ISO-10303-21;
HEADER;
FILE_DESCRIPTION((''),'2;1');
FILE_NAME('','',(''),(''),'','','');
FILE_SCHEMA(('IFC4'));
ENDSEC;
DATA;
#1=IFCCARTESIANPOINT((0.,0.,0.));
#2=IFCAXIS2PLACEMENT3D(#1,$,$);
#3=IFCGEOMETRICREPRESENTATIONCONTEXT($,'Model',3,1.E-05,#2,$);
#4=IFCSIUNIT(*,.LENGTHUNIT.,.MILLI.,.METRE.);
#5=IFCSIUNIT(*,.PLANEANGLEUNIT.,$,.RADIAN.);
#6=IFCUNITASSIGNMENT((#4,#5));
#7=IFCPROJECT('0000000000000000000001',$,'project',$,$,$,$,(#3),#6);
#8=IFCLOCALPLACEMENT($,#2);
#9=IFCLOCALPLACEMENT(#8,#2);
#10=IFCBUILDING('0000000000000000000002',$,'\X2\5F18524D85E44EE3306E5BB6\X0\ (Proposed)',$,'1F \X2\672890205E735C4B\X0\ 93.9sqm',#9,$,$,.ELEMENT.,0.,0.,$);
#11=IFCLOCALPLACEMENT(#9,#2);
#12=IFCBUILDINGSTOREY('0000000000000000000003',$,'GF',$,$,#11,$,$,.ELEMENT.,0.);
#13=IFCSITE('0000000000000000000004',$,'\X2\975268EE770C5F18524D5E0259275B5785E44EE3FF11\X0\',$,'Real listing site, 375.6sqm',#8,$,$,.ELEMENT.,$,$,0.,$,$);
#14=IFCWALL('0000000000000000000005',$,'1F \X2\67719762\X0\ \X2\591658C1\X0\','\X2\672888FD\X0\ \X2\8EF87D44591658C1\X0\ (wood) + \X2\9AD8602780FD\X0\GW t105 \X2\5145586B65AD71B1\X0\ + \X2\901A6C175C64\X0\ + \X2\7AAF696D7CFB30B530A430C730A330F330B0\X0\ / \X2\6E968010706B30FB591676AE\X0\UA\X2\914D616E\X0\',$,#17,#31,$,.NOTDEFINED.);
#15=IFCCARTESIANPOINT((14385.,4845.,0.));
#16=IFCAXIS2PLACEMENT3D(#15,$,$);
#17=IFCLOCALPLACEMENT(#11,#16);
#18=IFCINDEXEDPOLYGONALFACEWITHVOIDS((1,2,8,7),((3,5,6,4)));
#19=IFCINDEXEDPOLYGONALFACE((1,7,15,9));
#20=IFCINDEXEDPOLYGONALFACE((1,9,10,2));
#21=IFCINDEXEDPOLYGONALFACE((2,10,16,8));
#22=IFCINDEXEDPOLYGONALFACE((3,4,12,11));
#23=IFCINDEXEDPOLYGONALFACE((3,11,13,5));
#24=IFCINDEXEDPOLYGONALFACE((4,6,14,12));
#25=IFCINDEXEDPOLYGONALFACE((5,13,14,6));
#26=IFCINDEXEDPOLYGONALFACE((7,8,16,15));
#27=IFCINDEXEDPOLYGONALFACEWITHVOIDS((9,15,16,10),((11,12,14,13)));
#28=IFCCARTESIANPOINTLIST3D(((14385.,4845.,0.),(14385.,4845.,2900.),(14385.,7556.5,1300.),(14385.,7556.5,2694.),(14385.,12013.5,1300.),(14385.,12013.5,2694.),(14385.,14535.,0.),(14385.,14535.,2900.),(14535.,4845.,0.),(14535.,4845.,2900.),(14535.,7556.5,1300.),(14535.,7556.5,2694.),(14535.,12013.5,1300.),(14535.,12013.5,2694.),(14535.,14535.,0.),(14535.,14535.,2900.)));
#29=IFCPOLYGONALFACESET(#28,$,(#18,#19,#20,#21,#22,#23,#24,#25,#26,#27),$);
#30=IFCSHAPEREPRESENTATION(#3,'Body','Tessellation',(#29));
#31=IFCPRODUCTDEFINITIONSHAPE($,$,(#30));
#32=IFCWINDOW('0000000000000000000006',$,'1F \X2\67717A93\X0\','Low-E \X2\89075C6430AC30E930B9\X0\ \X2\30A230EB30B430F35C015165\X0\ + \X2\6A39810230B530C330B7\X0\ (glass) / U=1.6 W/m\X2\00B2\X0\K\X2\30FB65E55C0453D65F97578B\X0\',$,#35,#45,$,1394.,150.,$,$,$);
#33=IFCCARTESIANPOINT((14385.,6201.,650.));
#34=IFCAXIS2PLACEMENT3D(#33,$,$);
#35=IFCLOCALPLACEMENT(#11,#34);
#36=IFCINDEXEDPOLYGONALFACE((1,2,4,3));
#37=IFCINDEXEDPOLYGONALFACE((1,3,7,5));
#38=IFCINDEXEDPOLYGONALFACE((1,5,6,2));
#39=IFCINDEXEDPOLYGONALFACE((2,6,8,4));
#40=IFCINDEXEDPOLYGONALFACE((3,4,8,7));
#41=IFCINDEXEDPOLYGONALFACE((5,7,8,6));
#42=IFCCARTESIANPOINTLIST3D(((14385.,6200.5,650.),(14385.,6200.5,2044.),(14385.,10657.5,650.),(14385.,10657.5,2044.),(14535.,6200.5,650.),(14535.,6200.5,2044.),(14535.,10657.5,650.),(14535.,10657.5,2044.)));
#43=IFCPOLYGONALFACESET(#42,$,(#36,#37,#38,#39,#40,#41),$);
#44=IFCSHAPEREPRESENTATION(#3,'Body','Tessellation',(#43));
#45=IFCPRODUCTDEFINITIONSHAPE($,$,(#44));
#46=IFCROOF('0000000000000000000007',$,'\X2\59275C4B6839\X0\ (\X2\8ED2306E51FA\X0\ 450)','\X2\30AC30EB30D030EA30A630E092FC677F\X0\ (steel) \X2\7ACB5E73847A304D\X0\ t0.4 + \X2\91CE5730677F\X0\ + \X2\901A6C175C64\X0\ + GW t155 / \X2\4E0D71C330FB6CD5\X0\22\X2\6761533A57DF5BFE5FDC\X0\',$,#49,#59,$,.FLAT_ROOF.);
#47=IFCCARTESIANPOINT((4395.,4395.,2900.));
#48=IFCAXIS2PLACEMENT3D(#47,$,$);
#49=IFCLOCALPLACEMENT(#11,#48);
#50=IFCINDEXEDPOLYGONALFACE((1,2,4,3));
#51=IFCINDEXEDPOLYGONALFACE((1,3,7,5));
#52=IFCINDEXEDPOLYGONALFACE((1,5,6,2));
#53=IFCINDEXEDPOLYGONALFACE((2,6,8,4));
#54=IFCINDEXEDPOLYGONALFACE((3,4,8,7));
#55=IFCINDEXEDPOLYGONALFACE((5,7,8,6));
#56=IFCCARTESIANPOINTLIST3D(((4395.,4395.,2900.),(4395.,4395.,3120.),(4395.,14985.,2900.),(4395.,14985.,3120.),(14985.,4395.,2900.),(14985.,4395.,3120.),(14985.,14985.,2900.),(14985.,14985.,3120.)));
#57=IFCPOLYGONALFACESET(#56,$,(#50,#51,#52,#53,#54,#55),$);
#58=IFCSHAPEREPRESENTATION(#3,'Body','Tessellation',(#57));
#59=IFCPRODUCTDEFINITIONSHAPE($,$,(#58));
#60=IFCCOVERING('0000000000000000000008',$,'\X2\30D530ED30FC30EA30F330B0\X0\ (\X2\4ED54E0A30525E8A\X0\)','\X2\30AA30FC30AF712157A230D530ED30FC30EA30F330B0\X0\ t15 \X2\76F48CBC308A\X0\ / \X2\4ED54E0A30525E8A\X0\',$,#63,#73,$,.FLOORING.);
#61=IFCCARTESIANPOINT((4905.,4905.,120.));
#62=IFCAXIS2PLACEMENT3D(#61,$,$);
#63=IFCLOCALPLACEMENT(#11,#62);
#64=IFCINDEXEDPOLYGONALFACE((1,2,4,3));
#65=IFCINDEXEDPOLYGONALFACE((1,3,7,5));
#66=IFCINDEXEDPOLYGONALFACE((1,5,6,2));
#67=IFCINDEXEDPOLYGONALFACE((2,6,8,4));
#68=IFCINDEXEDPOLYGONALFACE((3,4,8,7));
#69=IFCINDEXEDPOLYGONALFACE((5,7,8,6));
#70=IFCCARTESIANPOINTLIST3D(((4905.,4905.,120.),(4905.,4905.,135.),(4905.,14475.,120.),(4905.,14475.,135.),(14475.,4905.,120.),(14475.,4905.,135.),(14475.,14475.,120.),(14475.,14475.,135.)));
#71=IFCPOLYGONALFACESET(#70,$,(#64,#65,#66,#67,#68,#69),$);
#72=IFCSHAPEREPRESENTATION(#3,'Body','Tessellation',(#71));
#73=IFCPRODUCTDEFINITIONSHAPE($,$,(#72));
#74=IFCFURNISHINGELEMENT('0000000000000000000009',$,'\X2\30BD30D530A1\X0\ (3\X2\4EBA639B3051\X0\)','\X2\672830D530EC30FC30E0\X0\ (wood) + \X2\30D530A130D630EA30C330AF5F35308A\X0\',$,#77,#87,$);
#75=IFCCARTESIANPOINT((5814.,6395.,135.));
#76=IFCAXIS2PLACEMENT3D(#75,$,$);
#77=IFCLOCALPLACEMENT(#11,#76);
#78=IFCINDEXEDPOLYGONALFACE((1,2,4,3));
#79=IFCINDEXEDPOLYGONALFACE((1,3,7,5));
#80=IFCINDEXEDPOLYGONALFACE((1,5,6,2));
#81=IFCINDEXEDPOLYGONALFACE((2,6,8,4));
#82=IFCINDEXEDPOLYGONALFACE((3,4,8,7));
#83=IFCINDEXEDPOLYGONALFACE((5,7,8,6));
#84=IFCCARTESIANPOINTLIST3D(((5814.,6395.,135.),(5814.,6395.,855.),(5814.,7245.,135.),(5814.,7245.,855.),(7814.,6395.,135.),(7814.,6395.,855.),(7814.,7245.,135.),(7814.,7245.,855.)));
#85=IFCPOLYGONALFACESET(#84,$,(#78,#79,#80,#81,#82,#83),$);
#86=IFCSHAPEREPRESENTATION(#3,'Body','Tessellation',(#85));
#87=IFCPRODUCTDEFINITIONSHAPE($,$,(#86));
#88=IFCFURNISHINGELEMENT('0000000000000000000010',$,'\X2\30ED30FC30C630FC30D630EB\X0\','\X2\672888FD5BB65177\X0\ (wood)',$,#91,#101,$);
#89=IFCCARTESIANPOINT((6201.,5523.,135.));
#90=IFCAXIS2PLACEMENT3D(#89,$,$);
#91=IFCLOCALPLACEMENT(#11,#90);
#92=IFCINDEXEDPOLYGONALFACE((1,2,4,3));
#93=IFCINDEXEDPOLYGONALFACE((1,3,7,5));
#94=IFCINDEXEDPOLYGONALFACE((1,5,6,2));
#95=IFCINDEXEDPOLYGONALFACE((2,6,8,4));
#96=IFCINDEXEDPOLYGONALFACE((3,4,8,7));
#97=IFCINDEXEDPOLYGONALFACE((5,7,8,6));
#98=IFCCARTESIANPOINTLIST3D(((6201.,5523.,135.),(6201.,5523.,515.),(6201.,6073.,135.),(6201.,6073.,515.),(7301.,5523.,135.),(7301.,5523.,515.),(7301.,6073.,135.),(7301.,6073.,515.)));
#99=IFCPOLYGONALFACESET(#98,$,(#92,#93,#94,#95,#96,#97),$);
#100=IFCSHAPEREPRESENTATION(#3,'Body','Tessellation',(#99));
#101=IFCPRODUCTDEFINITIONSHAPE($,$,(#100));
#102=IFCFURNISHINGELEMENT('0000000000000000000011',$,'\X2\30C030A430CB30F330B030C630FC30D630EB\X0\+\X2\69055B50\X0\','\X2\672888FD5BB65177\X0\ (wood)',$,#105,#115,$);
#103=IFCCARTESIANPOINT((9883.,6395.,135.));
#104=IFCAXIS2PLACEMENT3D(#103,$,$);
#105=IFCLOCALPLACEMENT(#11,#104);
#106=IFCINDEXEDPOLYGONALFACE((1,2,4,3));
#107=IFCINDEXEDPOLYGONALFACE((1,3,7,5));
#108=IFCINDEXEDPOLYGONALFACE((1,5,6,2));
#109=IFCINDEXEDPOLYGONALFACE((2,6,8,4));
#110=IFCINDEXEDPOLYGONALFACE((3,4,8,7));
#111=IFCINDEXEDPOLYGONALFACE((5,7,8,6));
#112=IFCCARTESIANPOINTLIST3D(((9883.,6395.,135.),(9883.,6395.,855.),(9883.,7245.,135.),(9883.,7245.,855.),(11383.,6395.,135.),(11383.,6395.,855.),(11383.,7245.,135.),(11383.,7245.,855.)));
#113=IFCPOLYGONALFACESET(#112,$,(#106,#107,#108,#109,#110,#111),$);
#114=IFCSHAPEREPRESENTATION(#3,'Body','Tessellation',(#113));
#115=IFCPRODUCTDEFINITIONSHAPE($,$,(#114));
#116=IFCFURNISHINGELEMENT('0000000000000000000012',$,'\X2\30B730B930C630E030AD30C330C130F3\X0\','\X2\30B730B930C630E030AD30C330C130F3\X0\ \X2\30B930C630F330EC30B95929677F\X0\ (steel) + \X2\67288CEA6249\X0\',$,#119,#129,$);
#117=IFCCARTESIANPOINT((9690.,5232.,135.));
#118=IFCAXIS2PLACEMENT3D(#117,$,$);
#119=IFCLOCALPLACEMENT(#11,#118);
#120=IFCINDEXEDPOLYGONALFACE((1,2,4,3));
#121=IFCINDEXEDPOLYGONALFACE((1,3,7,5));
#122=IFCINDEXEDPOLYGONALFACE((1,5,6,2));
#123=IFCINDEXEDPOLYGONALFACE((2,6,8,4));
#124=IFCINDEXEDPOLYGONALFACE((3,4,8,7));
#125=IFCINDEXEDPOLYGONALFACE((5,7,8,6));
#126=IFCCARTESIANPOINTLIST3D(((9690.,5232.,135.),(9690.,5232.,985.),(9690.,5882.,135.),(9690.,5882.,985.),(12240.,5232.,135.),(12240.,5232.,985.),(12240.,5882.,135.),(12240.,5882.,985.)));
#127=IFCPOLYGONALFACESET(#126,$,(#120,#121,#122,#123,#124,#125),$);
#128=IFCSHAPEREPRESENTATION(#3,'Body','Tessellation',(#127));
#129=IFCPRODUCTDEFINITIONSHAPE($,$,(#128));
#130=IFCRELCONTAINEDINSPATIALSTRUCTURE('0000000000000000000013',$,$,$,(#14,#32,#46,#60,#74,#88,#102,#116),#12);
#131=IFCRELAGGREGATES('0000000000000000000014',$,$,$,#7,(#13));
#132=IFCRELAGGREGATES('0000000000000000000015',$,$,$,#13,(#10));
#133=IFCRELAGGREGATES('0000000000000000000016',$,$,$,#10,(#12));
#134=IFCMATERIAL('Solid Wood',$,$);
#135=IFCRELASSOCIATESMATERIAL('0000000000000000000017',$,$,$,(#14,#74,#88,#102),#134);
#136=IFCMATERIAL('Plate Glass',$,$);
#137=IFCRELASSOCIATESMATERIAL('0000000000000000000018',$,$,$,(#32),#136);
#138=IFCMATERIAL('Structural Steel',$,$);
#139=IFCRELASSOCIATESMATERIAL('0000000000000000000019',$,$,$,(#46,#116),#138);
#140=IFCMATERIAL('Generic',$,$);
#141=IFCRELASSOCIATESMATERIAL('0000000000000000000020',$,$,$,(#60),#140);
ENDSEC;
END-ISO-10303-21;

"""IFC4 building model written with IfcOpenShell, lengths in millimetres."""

from ifc_helpers import new_model, si_unit, frame, frame_2d, origin, place, context, project, spatial, rectangle, extrude, material, element, fill, save


model = new_model("IFC4")

# Units and contexts
model_context = context("Model", 3, precision=1e-05, world=origin())
ifc_project = project(units=[si_unit("LENGTHUNIT", "METRE", prefix="MILLI"), si_unit("PLANEANGLEUNIT", "RADIAN")], contexts=[model_context])

# Site, building, storey
site_placement = place(None, origin())
site = spatial("IfcSite", under=ifc_project, at=site_placement, Name="青森県弘前市大字藤代１", ObjectType="Real listing site, 375.6sqm", CompositionType="ELEMENT", RefElevation=0.0)
building_placement = place(site_placement, origin())
building = spatial("IfcBuilding", under=site, at=building_placement, Name="弘前藤代の家 (Proposed)", ObjectType="1F 木造平屋 93.9sqm", CompositionType="ELEMENT", ElevationOfRefHeight=0.0, ElevationOfTerrain=0.0)
storey_placement = place(building_placement, origin())
storey = spatial("IfcBuildingStorey", under=building, at=storey_placement, Name="GF", CompositionType="ELEMENT", Elevation=0.0)

# Shared definitions
ifc_material_1 = material(Name="Solid Wood")

# Shared definitions
ifc_material_2 = material(Name="Plate Glass")

# Wall, opening, window
wall_1_placement = place(storey_placement, frame((14385.0, 4845.0, 0.0)))
wall_1 = element("IfcWall", 1, at=wall_1_placement, inside=storey, material=ifc_material_1, Name="1F 東面 外壁", Description="木製 軸組外壁 (wood) + 高性能GW t105 充填断熱 + 通気層 + 窯業系サイディング / 準耐火・外皮UA配慮", PredefinedType="NOTDEFINED", context=model_context, shape_type="SweptSolid", body=[
    extrude(rectangle(XDim=150.0, YDim=9690.0, at=frame_2d((75.0, 4845.0))), frame((14385.0, 4845.0, 0.0)), (0.0, 0.0, 1.0), 2900.0),
])
opening_1_placement = place(storey_placement, frame((14385.0, 6201.0, 650.0)))
opening_1 = element("IfcOpeningElement", 2, at=opening_1_placement, cuts=wall_1, PredefinedType="NOTDEFINED", context=model_context, shape_type="SweptSolid", body=[
    extrude(rectangle(XDim=150.0, YDim=4457.0, at=frame_2d((75.0, 2228.0))), frame((14385.0, 6201.0, 650.0)), (0.0, 0.0, 1.0), 1394.0),
])
window_1_placement = place(storey_placement, frame((14385.0, 6201.0, 650.0)))
window_1 = element("IfcWindow", 3, at=window_1_placement, inside=storey, material=ifc_material_2, Name="1F 東窓", Description="Low-E 複層ガラス アルゴン封入 + 樹脂サッシ (glass) / U=1.6 W/m²K・日射取得型", OverallHeight=1394.0, OverallWidth=150.0, context=model_context, shape_type="SweptSolid", body=[
    extrude(rectangle(XDim=150.0, YDim=4457.0, at=frame_2d((75.0, 2228.0))), frame((14385.0, 6201.0, 650.0)), (0.0, 0.0, 1.0), 1394.0),
])
fill(opening_1, window_1)

# Roof
ifc_material_3 = material(Name="Structural Steel")
roof_placement = place(storey_placement, frame((4395.0, 4395.0, 2900.0)))
element("IfcRoof", 4, at=roof_placement, inside=storey, material=ifc_material_3, Name="大屋根 (軒の出 450)", Description="ガルバリウム鋼板 (steel) 立平葺き t0.4 + 野地板 + 通気層 + GW t155 / 不燃・法22条区域対応", PredefinedType="FLAT_ROOF", context=model_context, shape_type="SweptSolid", body=[
    extrude(rectangle(XDim=10590.0, YDim=10590.0, at=frame_2d((5295.0, 5295.0))), frame((4395.0, 4395.0, 2900.0)), (0.0, 0.0, 1.0), 220.0),
])

# Covering
ifc_material_4 = material(Name="Generic")
covering_placement = place(storey_placement, frame((4905.0, 4905.0, 120.0)))
element("IfcCovering", 5, at=covering_placement, inside=storey, material=ifc_material_4, Name="フローリング (仕上げ床)", Description="オーク無垢フローリング t15 直貼り / 仕上げ床", PredefinedType="FLOORING", context=model_context, shape_type="SweptSolid", body=[
    extrude(rectangle(XDim=9570.0, YDim=9570.0, at=frame_2d((4785.0, 4785.0))), frame((4905.0, 4905.0, 120.0)), (0.0, 0.0, 1.0), 15.0),
])

# Furnishing elements
furnishing_1_placement = place(storey_placement, frame((5814.0, 6395.0, 135.0)))
element("IfcFurnishingElement", 6, at=furnishing_1_placement, inside=storey, material=ifc_material_1, Name="ソファ (3人掛け)", Description="木フレーム (wood) + ファブリック張り", context=model_context, shape_type="SweptSolid", body=[
    extrude(rectangle(XDim=2000.0, YDim=850.0, at=frame_2d((1000.0, 425.0))), frame((5814.0, 6395.0, 135.0)), (0.0, 0.0, 1.0), 720.0),
])
furnishing_2_placement = place(storey_placement, frame((6201.0, 5523.0, 135.0)))
element("IfcFurnishingElement", 7, at=furnishing_2_placement, inside=storey, material=ifc_material_1, Name="ローテーブル", Description="木製家具 (wood)", context=model_context, shape_type="SweptSolid", body=[
    extrude(rectangle(XDim=1100.0, YDim=550.0, at=frame_2d((550.0, 275.0))), frame((6201.0, 5523.0, 135.0)), (0.0, 0.0, 1.0), 380.0),
])
furnishing_3_placement = place(storey_placement, frame((9883.0, 6395.0, 135.0)))
element("IfcFurnishingElement", 8, at=furnishing_3_placement, inside=storey, material=ifc_material_1, Name="ダイニングテーブル+椅子", Description="木製家具 (wood)", context=model_context, shape_type="SweptSolid", body=[
    extrude(rectangle(XDim=1500.0, YDim=850.0, at=frame_2d((750.0, 425.0))), frame((9883.0, 6395.0, 135.0)), (0.0, 0.0, 1.0), 720.0),
])
furnishing_4_placement = place(storey_placement, frame((9690.0, 5232.0, 135.0)))
element("IfcFurnishingElement", 9, at=furnishing_4_placement, inside=storey, material=ifc_material_3, Name="システムキッチン", Description="システムキッチン ステンレス天板 (steel) + 木質扉", context=model_context, shape_type="SweptSolid", body=[
    extrude(rectangle(XDim=2550.0, YDim=650.0, at=frame_2d((1275.0, 325.0))), frame((9690.0, 5232.0, 135.0)), (0.0, 0.0, 1.0), 850.0),
])

save(model, "model.ifc")
